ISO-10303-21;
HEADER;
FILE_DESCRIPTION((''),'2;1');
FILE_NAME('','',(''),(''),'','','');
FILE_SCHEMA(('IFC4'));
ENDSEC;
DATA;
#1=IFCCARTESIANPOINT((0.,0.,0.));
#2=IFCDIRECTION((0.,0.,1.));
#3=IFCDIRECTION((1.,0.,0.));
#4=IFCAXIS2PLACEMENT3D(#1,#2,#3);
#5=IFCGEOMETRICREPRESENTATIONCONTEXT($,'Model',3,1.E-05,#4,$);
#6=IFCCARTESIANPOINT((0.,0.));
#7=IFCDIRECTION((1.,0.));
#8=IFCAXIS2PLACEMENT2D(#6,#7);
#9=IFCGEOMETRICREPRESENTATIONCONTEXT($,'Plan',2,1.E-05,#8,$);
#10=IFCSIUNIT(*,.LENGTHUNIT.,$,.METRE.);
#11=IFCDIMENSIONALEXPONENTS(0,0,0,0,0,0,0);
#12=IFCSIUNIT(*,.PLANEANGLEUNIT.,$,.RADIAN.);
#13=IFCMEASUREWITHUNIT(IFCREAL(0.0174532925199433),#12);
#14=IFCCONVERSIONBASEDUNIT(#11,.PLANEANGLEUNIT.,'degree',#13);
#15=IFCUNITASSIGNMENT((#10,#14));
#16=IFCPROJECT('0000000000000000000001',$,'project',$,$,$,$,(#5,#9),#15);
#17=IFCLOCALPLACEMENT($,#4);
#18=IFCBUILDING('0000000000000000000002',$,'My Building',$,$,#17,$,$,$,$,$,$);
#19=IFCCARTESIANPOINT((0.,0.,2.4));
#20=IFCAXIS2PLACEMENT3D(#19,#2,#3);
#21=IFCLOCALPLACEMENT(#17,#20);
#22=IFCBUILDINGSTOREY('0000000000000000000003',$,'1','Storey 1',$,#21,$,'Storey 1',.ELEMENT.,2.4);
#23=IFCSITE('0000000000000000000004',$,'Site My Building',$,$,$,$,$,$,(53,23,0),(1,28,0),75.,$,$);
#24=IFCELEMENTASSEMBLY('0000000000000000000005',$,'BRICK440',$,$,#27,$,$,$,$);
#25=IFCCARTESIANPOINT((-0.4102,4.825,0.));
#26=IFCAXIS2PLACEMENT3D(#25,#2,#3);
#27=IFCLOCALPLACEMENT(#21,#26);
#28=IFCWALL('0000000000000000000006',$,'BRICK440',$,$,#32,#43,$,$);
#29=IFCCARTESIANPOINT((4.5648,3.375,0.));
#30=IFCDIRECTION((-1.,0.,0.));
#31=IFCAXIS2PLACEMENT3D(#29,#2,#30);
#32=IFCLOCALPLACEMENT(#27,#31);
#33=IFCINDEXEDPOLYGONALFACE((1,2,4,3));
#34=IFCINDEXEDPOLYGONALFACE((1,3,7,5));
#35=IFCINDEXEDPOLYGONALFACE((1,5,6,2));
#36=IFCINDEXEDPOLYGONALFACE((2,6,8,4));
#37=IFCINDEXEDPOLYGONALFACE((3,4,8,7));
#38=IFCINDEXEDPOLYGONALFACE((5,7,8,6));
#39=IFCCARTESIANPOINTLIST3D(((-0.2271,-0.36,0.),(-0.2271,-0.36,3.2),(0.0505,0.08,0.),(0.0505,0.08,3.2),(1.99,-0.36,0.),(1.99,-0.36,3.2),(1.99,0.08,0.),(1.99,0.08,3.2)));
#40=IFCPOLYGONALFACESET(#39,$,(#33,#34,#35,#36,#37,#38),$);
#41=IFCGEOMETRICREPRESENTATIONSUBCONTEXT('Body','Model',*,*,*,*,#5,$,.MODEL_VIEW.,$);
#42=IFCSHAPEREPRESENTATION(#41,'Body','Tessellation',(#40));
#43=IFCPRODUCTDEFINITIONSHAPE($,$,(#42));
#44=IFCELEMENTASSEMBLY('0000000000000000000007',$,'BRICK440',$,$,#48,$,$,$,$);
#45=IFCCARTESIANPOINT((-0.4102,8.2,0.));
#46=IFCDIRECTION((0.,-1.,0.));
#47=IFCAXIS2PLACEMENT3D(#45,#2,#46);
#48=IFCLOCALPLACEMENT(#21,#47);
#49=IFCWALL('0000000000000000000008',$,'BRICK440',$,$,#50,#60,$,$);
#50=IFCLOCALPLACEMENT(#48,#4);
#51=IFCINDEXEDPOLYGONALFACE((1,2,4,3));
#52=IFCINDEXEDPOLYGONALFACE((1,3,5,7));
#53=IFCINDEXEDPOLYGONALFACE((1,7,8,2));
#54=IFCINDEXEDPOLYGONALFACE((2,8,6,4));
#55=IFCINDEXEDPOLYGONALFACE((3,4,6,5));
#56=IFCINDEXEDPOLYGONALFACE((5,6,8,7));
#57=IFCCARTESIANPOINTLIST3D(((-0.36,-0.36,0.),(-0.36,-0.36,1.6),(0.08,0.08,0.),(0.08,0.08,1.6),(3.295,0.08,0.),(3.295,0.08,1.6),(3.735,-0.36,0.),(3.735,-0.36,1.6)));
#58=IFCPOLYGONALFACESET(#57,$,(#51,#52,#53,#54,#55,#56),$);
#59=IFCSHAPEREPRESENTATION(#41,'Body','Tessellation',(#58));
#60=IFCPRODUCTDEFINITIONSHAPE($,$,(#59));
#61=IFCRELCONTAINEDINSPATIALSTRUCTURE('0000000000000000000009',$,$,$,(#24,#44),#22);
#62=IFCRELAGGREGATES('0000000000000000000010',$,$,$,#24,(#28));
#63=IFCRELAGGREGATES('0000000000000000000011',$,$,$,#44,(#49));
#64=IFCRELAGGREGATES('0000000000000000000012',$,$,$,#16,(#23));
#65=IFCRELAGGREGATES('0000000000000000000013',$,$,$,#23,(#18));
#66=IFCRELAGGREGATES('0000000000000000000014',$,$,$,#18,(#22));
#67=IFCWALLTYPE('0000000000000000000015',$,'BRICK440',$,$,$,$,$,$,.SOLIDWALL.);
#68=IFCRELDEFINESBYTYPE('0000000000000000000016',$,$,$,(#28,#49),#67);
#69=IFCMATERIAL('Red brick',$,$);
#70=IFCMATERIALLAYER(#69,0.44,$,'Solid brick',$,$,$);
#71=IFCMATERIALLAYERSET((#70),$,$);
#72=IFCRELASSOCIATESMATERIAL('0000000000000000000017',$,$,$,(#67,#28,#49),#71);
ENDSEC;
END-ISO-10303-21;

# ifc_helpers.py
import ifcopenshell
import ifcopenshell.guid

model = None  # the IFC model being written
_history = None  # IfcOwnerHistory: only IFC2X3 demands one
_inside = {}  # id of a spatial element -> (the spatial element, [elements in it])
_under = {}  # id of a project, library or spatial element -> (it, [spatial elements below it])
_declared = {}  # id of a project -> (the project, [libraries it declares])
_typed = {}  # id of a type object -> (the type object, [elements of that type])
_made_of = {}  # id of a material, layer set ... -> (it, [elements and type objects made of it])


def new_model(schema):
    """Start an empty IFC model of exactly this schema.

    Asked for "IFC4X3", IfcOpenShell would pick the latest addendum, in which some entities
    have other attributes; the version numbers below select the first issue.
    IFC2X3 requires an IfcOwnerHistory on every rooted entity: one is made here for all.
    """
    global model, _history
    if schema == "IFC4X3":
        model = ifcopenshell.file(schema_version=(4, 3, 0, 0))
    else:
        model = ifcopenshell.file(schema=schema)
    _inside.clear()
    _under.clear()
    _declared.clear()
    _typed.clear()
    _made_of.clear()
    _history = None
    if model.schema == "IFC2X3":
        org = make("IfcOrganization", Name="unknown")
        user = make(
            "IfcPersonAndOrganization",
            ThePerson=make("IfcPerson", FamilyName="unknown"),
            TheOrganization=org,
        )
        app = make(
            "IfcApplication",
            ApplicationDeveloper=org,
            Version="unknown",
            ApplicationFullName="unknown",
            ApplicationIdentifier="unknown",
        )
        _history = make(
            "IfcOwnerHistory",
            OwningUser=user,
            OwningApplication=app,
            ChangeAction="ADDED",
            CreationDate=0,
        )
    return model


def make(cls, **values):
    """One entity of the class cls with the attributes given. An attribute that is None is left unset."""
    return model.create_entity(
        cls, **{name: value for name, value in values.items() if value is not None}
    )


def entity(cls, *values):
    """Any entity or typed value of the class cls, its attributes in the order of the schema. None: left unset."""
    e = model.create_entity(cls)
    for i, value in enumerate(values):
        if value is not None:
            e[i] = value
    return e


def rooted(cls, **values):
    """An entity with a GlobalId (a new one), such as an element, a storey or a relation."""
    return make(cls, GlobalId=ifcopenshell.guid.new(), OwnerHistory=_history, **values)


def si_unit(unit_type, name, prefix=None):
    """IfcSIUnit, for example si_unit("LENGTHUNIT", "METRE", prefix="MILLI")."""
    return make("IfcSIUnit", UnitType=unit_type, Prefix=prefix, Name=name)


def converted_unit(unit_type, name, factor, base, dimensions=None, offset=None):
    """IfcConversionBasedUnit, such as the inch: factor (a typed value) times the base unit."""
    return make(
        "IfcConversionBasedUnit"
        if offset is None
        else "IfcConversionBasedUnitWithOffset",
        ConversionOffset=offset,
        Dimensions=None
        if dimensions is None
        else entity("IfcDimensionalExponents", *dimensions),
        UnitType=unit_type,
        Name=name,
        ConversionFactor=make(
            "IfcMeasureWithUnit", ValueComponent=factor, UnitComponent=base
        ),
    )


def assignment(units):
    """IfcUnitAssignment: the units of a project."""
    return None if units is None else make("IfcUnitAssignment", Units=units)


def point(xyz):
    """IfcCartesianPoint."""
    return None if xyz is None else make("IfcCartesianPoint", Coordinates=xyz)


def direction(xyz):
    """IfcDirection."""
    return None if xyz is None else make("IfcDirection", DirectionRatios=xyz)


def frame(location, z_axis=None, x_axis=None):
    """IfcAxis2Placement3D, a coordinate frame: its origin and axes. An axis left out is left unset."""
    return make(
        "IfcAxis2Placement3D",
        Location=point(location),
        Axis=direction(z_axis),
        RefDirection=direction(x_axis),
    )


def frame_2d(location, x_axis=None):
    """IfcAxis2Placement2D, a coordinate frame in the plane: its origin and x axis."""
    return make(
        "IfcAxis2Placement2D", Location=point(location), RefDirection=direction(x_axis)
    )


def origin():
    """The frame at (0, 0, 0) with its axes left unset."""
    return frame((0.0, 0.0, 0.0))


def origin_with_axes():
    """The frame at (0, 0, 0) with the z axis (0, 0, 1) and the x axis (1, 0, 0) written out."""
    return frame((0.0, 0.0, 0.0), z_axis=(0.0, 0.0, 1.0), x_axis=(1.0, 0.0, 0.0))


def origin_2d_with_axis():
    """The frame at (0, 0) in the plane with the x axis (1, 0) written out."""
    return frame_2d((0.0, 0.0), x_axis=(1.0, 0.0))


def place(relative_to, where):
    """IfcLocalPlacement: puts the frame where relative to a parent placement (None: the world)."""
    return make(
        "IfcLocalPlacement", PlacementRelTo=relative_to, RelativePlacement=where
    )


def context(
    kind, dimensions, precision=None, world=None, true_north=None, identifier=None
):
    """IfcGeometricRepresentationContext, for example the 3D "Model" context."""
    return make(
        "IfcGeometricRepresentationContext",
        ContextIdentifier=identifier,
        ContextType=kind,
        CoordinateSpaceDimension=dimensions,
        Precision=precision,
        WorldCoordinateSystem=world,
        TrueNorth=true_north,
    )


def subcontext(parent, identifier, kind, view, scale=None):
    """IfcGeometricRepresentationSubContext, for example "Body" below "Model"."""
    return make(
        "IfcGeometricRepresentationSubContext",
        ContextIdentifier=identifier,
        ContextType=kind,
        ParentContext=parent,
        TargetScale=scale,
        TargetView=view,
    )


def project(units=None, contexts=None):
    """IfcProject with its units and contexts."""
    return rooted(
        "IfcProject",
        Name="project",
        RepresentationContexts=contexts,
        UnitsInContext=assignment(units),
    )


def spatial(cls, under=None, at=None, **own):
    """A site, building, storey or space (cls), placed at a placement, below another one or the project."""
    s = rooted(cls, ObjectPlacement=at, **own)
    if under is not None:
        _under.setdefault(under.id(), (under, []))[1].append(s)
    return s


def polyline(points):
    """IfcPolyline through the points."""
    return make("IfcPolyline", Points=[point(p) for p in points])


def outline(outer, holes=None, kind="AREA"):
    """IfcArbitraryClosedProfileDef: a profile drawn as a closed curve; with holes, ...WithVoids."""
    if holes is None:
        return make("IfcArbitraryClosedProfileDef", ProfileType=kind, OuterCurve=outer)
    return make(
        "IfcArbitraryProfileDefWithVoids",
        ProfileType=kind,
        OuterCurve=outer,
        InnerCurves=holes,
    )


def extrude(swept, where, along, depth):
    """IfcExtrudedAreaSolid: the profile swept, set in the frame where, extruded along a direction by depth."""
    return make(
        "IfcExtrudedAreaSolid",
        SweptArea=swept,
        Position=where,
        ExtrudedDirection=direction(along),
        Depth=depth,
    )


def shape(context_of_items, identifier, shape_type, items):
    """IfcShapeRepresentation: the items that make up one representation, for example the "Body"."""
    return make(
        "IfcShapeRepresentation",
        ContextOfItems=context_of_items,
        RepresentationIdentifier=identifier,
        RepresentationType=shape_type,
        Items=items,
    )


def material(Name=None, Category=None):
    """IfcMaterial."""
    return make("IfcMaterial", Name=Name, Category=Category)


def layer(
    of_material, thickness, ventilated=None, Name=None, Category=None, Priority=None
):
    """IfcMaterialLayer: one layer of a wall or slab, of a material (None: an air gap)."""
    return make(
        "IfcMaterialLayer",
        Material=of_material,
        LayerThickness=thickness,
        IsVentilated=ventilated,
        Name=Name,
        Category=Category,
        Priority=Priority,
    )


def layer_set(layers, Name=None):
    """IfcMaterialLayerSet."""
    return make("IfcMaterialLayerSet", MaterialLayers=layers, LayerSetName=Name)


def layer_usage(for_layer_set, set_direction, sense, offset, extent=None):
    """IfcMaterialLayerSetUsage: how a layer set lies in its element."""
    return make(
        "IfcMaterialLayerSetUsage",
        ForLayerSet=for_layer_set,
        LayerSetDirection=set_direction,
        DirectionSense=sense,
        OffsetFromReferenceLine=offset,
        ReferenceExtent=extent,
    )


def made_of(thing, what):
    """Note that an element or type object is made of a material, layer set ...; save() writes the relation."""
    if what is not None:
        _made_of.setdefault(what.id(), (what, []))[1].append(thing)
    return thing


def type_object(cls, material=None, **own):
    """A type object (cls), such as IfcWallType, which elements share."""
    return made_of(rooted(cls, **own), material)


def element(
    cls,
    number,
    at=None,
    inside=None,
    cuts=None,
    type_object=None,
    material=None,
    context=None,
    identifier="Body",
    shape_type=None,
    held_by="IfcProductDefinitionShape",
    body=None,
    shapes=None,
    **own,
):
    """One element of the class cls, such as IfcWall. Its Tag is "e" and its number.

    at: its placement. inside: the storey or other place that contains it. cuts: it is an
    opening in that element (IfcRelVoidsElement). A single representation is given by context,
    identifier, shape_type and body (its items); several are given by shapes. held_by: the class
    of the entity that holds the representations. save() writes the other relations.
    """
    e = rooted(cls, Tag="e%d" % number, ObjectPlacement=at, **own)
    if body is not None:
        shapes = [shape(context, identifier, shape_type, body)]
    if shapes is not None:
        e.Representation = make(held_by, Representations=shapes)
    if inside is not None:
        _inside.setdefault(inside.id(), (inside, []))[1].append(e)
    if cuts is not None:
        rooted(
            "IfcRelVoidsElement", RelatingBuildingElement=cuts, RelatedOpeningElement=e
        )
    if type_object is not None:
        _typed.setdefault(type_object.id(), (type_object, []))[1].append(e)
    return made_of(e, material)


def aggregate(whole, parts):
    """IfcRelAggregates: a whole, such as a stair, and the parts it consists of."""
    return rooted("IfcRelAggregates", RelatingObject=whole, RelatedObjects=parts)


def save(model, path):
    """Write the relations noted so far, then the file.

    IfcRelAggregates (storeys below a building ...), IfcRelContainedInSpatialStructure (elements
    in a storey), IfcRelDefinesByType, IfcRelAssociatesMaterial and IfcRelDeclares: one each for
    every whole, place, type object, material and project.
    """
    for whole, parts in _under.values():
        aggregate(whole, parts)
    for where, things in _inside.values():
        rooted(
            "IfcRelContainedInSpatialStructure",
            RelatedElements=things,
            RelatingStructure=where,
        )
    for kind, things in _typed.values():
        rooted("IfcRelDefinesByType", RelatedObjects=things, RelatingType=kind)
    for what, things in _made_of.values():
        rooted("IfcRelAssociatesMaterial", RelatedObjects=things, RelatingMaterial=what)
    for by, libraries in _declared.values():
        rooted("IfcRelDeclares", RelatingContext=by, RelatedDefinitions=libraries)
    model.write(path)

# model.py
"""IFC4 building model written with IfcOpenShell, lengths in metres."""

from ifc_helpers import new_model, entity, si_unit, converted_unit, frame, origin, origin_with_axes, origin_2d_with_axis, place, context, subcontext, project, spatial, polyline, outline, extrude, material, layer, layer_set, layer_usage, type_object, element, aggregate, save


model = new_model("IFC4")

# Units and contexts
model_context = context("Model", 3, precision=1e-05, world=origin_with_axes())
plan_context = context("Plan", 2, precision=1e-05, world=origin_2d_with_axis())
body_context = subcontext(model_context, "Body", "Model", "MODEL_VIEW")
ifc_project = project(units=[si_unit("LENGTHUNIT", "METRE"), converted_unit("PLANEANGLEUNIT", "degree", entity("IfcReal", 0.0174532925199433), si_unit("PLANEANGLEUNIT", "RADIAN"), dimensions=[0, 0, 0, 0, 0, 0, 0])], contexts=[model_context, plan_context])

# Site, building, storey
site = spatial("IfcSite", under=ifc_project, Name="Site My Building", RefLatitude=(53, 23, 0), RefLongitude=(1, 28, 0), RefElevation=75.0)
building_placement = place(None, origin_with_axes())
building = spatial("IfcBuilding", under=site, at=building_placement, Name="My Building")
storey_placement = place(building_placement, frame((0.0, 0.0, 2.4), z_axis=(0.0, 0.0, 1.0), x_axis=(1.0, 0.0, 0.0)))
storey = spatial("IfcBuildingStorey", under=building, at=storey_placement, Name="1", Description="Storey 1", LongName="Storey 1", CompositionType="ELEMENT", Elevation=2.4)

# Element assemblies, walls
assembly_1_placement = place(storey_placement, frame((-0.4102, 4.825, 0.0), z_axis=(0.0, 0.0, 1.0), x_axis=(1.0, 0.0, 0.0)))
assembly_1 = element("IfcElementAssembly", 1, at=assembly_1_placement, inside=storey, Name="BRICK440")
ifc_material_1 = material(Name="Red brick")
ifc_layer_1 = layer(ifc_material_1, 0.44, Name="Solid brick")
ifc_layer_set_1 = layer_set([ifc_layer_1])
ifc_layer_usage_1 = layer_usage(ifc_layer_set_1, "AXIS2", "POSITIVE", -0.36)
wall_type_1 = type_object("IfcWallType", Name="BRICK440", PredefinedType="SOLIDWALL", material=ifc_layer_set_1)
wall_1_placement = place(assembly_1_placement, frame((4.5648, 3.375, 0.0), z_axis=(0.0, 0.0, 1.0), x_axis=(-1.0, 0.0, 0.0)))
wall_1 = element("IfcWall", 2, at=wall_1_placement, type_object=wall_type_1, material=ifc_layer_usage_1, Name="BRICK440", context=body_context, shape_type="SweptSolid", body=[
    extrude(outline(polyline([(0.0505, 0.08), (-0.2271, -0.36), (1.99, -0.36), (1.99, 0.08), (0.0505, 0.08)])), origin(), (0.0, 0.0, 1.0), 3.2),
])
aggregate(assembly_1, [wall_1])
assembly_2_placement = place(storey_placement, frame((-0.4102, 8.2, 0.0), z_axis=(0.0, 0.0, 1.0), x_axis=(0.0, -1.0, 0.0)))
assembly_2 = element("IfcElementAssembly", 3, at=assembly_2_placement, inside=storey, Name="BRICK440")
ifc_layer_usage_2 = layer_usage(ifc_layer_set_1, "AXIS2", "POSITIVE", -0.36)
wall_2_placement = place(assembly_2_placement, origin_with_axes())
wall_2 = element("IfcWall", 4, at=wall_2_placement, type_object=wall_type_1, material=ifc_layer_usage_2, Name="BRICK440", context=body_context, shape_type="SweptSolid", body=[
    extrude(outline(polyline([(0.08, 0.08), (-0.36, -0.36), (3.735, -0.36), (3.295, 0.08), (0.08, 0.08)])), origin(), (0.0, 0.0, 1.0), 1.6),
])
aggregate(assembly_2, [wall_2])

save(model, "model.ifc")
